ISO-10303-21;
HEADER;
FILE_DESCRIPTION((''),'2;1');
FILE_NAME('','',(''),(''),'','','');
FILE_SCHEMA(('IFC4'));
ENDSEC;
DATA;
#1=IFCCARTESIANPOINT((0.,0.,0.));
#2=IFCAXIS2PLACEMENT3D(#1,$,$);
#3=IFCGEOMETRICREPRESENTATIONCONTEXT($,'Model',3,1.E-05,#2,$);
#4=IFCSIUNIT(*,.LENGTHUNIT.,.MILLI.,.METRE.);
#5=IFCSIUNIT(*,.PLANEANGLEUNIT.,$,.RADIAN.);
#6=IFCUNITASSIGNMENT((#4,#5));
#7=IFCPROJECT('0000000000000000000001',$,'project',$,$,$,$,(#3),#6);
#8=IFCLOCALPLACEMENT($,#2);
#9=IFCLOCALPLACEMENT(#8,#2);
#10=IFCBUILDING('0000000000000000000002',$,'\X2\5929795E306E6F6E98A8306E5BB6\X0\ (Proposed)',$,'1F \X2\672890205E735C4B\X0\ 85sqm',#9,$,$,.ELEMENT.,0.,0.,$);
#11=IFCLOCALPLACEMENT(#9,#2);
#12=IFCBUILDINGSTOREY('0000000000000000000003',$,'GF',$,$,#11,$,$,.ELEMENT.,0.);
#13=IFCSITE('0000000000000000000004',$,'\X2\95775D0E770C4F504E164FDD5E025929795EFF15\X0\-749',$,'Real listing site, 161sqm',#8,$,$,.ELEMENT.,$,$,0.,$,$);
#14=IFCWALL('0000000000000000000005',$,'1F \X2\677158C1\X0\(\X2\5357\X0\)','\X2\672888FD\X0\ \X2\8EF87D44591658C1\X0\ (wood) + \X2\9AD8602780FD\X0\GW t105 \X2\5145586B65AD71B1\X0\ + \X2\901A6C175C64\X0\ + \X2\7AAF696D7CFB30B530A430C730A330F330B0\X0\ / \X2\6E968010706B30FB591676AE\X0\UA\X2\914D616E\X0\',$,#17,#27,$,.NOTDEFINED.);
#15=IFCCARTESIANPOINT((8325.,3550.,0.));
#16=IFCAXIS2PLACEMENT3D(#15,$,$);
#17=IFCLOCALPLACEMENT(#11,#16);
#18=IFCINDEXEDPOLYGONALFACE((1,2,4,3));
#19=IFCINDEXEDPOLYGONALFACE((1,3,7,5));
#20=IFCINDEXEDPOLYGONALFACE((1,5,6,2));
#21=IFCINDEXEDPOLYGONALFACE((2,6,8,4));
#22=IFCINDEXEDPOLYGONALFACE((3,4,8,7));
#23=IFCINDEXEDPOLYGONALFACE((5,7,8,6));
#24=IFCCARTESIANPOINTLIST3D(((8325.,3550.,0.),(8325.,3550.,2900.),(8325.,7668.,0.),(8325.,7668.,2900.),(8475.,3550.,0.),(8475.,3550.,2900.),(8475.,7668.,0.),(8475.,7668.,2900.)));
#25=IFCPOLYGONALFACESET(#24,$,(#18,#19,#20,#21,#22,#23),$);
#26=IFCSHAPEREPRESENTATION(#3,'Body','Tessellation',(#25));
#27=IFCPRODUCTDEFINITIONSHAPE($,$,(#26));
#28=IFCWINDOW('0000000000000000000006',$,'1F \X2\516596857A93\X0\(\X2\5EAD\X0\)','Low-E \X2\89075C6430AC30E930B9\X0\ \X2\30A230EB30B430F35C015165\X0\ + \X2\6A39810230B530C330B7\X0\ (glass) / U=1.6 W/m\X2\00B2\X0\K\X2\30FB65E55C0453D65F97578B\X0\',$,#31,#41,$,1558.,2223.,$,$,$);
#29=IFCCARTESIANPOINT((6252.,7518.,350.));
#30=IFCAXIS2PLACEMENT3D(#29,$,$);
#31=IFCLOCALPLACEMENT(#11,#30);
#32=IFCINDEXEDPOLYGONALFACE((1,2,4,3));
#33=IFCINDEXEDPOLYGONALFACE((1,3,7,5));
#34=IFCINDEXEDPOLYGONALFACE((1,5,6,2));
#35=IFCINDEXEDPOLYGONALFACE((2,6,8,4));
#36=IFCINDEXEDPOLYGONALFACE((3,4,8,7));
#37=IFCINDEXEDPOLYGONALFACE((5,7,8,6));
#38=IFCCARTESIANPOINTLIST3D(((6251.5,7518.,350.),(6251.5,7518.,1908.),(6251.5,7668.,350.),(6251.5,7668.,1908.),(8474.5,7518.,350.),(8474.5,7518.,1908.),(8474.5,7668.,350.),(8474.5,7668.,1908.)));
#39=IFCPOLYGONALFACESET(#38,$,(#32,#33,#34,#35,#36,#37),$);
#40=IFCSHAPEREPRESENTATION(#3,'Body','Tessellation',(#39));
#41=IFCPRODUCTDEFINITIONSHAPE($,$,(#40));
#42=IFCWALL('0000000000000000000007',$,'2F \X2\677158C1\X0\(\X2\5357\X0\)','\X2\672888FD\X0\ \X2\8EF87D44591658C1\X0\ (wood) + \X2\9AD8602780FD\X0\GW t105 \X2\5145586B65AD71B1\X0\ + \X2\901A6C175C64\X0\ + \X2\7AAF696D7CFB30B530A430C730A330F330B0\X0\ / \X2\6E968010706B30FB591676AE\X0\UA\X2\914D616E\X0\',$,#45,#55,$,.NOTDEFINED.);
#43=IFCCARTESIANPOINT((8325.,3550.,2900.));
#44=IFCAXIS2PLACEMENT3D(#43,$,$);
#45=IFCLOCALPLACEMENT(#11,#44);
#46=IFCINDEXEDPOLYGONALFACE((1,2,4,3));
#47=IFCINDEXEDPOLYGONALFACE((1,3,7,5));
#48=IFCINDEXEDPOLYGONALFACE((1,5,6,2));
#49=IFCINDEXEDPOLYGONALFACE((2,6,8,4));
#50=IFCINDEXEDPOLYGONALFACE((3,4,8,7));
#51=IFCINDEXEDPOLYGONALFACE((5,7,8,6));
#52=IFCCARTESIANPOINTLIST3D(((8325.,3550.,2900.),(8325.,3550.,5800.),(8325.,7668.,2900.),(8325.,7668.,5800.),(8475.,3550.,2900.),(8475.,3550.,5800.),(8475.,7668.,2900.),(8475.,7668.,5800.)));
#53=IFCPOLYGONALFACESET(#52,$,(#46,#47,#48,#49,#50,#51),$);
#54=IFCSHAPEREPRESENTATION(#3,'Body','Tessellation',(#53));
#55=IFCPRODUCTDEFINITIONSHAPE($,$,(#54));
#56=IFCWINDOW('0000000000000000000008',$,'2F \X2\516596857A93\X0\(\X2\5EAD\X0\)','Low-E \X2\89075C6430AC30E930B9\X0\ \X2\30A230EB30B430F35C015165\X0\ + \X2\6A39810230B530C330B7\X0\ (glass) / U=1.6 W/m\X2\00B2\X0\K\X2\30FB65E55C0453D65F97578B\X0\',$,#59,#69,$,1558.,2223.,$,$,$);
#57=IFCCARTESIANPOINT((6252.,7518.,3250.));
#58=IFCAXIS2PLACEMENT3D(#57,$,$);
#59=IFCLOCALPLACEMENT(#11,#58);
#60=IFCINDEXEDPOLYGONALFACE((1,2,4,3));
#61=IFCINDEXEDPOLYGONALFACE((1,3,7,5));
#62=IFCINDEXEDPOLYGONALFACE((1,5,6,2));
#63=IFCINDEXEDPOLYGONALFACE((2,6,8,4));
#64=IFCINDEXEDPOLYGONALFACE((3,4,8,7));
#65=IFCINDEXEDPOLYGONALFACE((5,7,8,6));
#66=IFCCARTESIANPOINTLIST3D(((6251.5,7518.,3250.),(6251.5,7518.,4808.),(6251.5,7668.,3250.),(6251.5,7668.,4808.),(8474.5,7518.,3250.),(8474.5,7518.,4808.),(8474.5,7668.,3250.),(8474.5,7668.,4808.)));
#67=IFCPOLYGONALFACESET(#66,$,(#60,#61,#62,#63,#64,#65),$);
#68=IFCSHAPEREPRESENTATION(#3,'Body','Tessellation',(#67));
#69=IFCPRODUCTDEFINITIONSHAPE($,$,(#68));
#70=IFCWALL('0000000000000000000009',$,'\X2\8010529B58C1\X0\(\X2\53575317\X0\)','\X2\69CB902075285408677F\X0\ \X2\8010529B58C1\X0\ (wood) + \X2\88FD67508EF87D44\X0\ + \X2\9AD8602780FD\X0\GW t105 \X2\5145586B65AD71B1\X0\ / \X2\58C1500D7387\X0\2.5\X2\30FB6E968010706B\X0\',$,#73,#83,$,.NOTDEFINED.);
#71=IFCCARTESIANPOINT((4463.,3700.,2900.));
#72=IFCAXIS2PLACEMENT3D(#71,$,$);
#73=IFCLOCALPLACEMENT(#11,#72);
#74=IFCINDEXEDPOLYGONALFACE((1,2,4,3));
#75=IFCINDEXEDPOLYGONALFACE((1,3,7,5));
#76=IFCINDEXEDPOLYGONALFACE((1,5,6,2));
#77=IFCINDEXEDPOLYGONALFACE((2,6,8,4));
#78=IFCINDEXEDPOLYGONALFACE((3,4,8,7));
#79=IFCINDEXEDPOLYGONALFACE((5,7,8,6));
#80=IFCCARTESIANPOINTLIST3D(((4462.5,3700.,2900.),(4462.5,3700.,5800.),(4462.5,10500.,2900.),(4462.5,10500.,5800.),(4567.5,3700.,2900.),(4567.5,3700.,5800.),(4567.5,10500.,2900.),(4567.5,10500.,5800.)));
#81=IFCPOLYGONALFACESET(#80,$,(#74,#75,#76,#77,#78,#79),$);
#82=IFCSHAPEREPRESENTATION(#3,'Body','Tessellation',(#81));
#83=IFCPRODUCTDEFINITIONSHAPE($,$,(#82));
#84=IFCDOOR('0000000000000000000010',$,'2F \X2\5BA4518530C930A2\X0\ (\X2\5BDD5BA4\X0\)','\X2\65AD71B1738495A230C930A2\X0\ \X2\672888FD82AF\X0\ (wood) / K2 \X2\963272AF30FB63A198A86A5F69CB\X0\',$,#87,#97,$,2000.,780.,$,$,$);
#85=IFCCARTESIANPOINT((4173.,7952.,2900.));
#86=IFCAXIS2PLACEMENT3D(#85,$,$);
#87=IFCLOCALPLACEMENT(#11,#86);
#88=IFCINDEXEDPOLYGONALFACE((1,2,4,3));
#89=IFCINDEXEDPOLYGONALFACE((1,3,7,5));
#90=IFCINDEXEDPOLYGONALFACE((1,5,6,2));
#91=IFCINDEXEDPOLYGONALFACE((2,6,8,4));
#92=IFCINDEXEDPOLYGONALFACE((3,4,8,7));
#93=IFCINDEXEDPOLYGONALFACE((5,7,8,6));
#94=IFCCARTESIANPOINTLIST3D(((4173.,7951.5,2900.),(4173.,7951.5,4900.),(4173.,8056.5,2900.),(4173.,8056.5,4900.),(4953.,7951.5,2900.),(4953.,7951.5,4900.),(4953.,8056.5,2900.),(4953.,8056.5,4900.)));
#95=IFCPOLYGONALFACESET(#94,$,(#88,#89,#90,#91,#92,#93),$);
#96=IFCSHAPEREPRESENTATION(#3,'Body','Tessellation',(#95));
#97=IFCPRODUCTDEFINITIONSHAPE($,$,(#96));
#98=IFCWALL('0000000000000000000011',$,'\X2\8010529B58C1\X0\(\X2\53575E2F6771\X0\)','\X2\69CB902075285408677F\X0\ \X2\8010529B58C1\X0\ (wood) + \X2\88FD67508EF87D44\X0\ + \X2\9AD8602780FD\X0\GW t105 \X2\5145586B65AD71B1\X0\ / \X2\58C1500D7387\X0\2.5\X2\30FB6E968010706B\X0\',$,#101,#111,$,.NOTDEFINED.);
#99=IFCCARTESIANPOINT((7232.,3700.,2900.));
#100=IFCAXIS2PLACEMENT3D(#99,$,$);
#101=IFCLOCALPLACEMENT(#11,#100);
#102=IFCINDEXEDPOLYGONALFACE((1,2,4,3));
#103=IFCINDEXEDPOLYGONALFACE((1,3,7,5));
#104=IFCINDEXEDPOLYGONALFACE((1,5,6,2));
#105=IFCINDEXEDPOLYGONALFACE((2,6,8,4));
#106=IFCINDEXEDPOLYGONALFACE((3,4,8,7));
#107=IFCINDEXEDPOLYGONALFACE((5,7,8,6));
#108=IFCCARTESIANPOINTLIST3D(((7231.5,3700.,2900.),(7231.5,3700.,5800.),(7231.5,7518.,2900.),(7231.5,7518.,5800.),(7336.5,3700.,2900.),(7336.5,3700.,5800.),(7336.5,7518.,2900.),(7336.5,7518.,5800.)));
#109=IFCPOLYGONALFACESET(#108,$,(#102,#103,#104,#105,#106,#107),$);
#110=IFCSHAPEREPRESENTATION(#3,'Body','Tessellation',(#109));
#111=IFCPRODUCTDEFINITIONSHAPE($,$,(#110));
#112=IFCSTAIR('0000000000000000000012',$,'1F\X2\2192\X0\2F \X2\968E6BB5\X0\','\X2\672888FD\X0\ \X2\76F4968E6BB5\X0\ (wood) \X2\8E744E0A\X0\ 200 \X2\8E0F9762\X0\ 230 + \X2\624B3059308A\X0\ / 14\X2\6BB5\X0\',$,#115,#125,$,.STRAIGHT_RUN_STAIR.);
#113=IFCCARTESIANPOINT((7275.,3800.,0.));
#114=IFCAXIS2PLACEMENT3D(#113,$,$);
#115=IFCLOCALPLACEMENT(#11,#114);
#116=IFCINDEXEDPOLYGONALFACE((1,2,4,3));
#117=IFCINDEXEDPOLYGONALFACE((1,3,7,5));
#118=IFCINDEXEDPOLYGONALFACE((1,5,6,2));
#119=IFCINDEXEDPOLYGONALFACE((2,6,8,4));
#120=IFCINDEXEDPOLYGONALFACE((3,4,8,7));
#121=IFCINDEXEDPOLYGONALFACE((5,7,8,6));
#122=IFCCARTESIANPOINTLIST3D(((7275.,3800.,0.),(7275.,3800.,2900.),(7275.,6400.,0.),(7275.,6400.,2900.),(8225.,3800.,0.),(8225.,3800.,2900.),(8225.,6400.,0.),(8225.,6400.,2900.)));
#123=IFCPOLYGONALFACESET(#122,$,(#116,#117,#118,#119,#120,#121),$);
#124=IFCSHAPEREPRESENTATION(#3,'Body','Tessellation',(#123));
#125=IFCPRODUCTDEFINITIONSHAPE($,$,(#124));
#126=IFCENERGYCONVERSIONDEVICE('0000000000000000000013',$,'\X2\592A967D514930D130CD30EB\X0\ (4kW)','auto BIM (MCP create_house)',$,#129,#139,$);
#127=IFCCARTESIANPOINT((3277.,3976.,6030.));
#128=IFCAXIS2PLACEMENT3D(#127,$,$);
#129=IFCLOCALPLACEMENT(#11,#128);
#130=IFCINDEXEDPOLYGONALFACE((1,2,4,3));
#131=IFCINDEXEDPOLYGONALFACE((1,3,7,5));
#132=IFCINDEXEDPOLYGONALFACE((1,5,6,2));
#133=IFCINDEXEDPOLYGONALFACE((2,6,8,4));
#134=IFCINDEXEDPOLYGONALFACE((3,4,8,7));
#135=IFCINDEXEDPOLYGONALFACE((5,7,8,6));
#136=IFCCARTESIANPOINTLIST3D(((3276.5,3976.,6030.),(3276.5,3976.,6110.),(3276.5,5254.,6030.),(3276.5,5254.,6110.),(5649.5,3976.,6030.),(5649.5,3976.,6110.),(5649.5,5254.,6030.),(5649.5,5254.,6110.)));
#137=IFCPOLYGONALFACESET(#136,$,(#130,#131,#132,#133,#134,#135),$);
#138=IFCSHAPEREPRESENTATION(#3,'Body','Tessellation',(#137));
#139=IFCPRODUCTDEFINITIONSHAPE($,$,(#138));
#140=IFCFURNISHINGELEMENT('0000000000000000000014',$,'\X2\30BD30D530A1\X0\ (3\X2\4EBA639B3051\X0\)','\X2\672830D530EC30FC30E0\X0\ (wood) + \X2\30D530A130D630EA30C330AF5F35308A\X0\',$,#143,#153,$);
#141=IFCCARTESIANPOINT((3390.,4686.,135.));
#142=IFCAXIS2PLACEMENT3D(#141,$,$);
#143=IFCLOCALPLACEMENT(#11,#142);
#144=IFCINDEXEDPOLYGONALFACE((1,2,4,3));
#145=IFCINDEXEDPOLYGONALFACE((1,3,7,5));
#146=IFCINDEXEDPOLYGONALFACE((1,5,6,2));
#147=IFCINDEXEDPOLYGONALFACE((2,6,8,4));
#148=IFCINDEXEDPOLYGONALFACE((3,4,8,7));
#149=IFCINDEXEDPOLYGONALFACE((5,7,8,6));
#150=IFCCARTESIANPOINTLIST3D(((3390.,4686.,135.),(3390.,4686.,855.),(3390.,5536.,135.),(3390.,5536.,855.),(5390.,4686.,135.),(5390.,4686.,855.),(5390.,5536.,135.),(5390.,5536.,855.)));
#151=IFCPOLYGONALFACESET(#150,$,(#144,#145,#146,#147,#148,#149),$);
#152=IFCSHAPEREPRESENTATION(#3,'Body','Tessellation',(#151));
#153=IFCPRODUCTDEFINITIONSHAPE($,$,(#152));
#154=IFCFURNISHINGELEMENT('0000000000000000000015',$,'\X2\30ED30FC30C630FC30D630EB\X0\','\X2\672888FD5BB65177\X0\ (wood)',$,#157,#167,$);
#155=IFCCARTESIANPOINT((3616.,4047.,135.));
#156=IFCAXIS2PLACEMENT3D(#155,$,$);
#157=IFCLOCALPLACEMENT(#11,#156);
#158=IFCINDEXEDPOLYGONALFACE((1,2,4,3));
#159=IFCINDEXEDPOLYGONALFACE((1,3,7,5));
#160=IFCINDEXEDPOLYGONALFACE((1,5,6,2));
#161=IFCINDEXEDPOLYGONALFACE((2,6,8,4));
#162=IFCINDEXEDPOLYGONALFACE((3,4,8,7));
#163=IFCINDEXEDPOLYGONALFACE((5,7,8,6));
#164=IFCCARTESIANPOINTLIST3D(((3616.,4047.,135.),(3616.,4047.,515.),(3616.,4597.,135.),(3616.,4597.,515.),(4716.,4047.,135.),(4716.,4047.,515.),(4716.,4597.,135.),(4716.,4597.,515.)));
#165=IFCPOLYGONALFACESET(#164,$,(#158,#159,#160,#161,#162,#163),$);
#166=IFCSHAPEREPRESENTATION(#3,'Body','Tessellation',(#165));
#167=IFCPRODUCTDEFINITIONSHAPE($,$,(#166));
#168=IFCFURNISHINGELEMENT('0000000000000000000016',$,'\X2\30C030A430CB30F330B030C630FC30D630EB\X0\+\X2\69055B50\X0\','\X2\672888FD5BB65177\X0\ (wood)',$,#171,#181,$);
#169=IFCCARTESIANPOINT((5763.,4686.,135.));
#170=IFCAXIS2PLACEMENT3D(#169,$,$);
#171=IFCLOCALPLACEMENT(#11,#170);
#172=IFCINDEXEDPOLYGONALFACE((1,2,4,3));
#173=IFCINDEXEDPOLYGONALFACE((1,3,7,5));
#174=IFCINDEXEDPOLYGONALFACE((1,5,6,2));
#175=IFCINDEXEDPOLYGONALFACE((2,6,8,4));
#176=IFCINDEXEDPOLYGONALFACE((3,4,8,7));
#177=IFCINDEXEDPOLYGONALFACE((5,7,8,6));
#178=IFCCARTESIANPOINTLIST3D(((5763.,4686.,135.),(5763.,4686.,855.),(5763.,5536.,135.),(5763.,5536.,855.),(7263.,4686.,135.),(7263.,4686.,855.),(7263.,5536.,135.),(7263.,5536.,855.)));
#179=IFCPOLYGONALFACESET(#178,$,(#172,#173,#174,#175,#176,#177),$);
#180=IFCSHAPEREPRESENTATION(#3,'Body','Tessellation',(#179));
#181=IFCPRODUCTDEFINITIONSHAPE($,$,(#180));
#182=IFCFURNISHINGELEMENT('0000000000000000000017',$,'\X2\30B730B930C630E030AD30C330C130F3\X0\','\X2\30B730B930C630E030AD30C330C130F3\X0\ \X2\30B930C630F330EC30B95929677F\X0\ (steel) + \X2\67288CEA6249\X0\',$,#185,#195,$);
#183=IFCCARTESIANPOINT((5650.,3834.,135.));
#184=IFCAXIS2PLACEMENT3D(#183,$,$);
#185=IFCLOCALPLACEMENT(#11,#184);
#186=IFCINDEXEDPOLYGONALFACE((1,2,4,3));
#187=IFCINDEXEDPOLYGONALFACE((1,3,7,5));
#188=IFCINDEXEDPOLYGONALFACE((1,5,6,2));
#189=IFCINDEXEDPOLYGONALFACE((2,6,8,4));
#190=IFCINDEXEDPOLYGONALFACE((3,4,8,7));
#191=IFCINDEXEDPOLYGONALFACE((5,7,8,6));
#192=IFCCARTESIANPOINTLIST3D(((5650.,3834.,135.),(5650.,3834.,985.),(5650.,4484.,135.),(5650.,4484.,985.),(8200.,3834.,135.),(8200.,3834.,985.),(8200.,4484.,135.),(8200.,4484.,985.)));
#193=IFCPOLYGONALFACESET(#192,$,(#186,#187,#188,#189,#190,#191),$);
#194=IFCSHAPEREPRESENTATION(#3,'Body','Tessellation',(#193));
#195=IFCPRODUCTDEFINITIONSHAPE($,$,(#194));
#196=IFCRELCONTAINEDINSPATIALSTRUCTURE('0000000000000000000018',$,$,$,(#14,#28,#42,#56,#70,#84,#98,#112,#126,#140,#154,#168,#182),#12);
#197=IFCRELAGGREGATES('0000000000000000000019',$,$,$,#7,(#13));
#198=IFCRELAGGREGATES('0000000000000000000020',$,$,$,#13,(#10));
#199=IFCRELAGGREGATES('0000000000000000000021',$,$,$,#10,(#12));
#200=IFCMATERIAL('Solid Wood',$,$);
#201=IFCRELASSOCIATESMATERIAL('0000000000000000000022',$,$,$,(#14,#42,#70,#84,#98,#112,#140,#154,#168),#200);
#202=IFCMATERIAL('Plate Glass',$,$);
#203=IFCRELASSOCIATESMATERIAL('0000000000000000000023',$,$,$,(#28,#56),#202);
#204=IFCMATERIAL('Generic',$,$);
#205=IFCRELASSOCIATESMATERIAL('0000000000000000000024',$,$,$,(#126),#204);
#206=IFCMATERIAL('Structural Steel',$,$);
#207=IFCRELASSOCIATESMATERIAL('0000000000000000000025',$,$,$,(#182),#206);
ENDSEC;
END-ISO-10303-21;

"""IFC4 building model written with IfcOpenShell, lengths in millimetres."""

from ifc_helpers import new_model, si_unit, frame, frame_2d, origin, place, context, project, spatial, rectangle, extrude, material, element, fill, save


model = new_model("IFC4")

# Units and contexts
model_context = context("Model", 3, precision=1e-05, world=origin())
ifc_project = project(units=[si_unit("LENGTHUNIT", "METRE", prefix="MILLI"), si_unit("PLANEANGLEUNIT", "RADIAN")], contexts=[model_context])

# Site, building, storey
site_placement = place(None, origin())
site = spatial("IfcSite", under=ifc_project, at=site_placement, Name="長崎県佐世保市天神５-749", ObjectType="Real listing site, 161sqm", CompositionType="ELEMENT", RefElevation=0.0)
building_placement = place(site_placement, origin())
building = spatial("IfcBuilding", under=site, at=building_placement, Name="天神の潮風の家 (Proposed)", ObjectType="1F 木造平屋 85sqm", CompositionType="ELEMENT", ElevationOfRefHeight=0.0, ElevationOfTerrain=0.0)
storey_placement = place(building_placement, origin())
storey = spatial("IfcBuildingStorey", under=building, at=storey_placement, Name="GF", CompositionType="ELEMENT", Elevation=0.0)

# Wall, opening, window
ifc_material_1 = material(Name="Solid Wood")
wall_1_placement = place(storey_placement, frame((8325.0, 3550.0, 0.0)))
wall_1 = element("IfcWall", 1, at=wall_1_placement, inside=storey, material=ifc_material_1, Name="1F 東壁(南)", Description="木製 軸組外壁 (wood) + 高性能GW t105 充填断熱 + 通気層 + 窯業系サイディング / 準耐火・外皮UA配慮", PredefinedType="NOTDEFINED", context=model_context, shape_type="SweptSolid", body=[
    extrude(rectangle(XDim=150.0, YDim=4118.0, at=frame_2d((75.0, 2059.0))), frame((8325.0, 3550.0, 0.0)), (0.0, 0.0, 1.0), 2900.0),
])
opening_1_placement = place(storey_placement, frame((6252.0, 7518.0, 350.0)))
opening_1 = element("IfcOpeningElement", 2, at=opening_1_placement, cuts=wall_1, PredefinedType="NOTDEFINED", context=model_context, shape_type="SweptSolid", body=[
    extrude(rectangle(XDim=2223.0, YDim=150.0, at=frame_2d((1111.0, 75.0))), frame((6252.0, 7518.0, 350.0)), (0.0, 0.0, 1.0), 1558.0),
])
ifc_material_2 = material(Name="Plate Glass")
window_1_placement = place(storey_placement, frame((6252.0, 7518.0, 350.0)))
window_1 = element("IfcWindow", 3, at=window_1_placement, inside=storey, material=ifc_material_2, Name="1F 入隅窓(庭)", Description="Low-E 複層ガラス アルゴン封入 + 樹脂サッシ (glass) / U=1.6 W/m²K・日射取得型", OverallHeight=1558.0, OverallWidth=2223.0, context=model_context, shape_type="SweptSolid", body=[
    extrude(rectangle(XDim=2223.0, YDim=150.0, at=frame_2d((1111.0, 75.0))), frame((6252.0, 7518.0, 350.0)), (0.0, 0.0, 1.0), 1558.0),
])
fill(opening_1, window_1)

# Wall, opening, window
wall_2_placement = place(storey_placement, frame((8325.0, 3550.0, 2900.0)))
wall_2 = element("IfcWall", 4, at=wall_2_placement, inside=storey, material=ifc_material_1, Name="2F 東壁(南)", Description="木製 軸組外壁 (wood) + 高性能GW t105 充填断熱 + 通気層 + 窯業系サイディング / 準耐火・外皮UA配慮", PredefinedType="NOTDEFINED", context=model_context, shape_type="SweptSolid", body=[
    extrude(rectangle(XDim=150.0, YDim=4118.0, at=frame_2d((75.0, 2059.0))), frame((8325.0, 3550.0, 2900.0)), (0.0, 0.0, 1.0), 2900.0),
])
opening_2_placement = place(storey_placement, frame((6252.0, 7518.0, 3250.0)))
opening_2 = element("IfcOpeningElement", 5, at=opening_2_placement, cuts=wall_2, PredefinedType="NOTDEFINED", context=model_context, shape_type="SweptSolid", body=[
    extrude(rectangle(XDim=2223.0, YDim=150.0, at=frame_2d((1111.0, 75.0))), frame((6252.0, 7518.0, 3250.0)), (0.0, 0.0, 1.0), 1558.0),
])
window_2_placement = place(storey_placement, frame((6252.0, 7518.0, 3250.0)))
window_2 = element("IfcWindow", 6, at=window_2_placement, inside=storey, material=ifc_material_2, Name="2F 入隅窓(庭)", Description="Low-E 複層ガラス アルゴン封入 + 樹脂サッシ (glass) / U=1.6 W/m²K・日射取得型", OverallHeight=1558.0, OverallWidth=2223.0, context=model_context, shape_type="SweptSolid", body=[
    extrude(rectangle(XDim=2223.0, YDim=150.0, at=frame_2d((1111.0, 75.0))), frame((6252.0, 7518.0, 3250.0)), (0.0, 0.0, 1.0), 1558.0),
])
fill(opening_2, window_2)

# Wall, opening, door
wall_3_placement = place(storey_placement, frame((4463.0, 3700.0, 2900.0)))
wall_3 = element("IfcWall", 7, at=wall_3_placement, inside=storey, material=ifc_material_1, Name="耐力壁(南北)", Description="構造用合板 耐力壁 (wood) + 製材軸組 + 高性能GW t105 充填断熱 / 壁倍率2.5・準耐火", PredefinedType="NOTDEFINED", context=model_context, shape_type="SweptSolid", body=[
    extrude(rectangle(XDim=105.0, YDim=6800.0, at=frame_2d((52.0, 3400.0))), frame((4463.0, 3700.0, 2900.0)), (0.0, 0.0, 1.0), 2900.0),
])
opening_3_placement = place(storey_placement, frame((4173.0, 7952.0, 2900.0)))
opening_3 = element("IfcOpeningElement", 8, at=opening_3_placement, cuts=wall_3, PredefinedType="NOTDEFINED", context=model_context, shape_type="SweptSolid", body=[
    extrude(rectangle(XDim=780.0, YDim=105.0, at=frame_2d((390.0, 52.0))), frame((4173.0, 7952.0, 2900.0)), (0.0, 0.0, 1.0), 2000.0),
])
door_1_placement = place(storey_placement, frame((4173.0, 7952.0, 2900.0)))
door_1 = element("IfcDoor", 9, at=door_1_placement, inside=storey, material=ifc_material_1, Name="2F 室内ドア (寝室)", Description="断熱玄関ドア 木製芯 (wood) / K2 防犯・採風機構", OverallHeight=2000.0, OverallWidth=780.0, context=model_context, shape_type="SweptSolid", body=[
    extrude(rectangle(XDim=780.0, YDim=105.0, at=frame_2d((390.0, 52.0))), frame((4173.0, 7952.0, 2900.0)), (0.0, 0.0, 1.0), 2000.0),
])
fill(opening_3, door_1)

# Wall
wall_4_placement = place(storey_placement, frame((7232.0, 3700.0, 2900.0)))
element("IfcWall", 10, at=wall_4_placement, inside=storey, material=ifc_material_1, Name="耐力壁(南帯東)", Description="構造用合板 耐力壁 (wood) + 製材軸組 + 高性能GW t105 充填断熱 / 壁倍率2.5・準耐火", PredefinedType="NOTDEFINED", context=model_context, shape_type="SweptSolid", body=[
    extrude(rectangle(XDim=105.0, YDim=3818.0, at=frame_2d((52.0, 1909.0))), frame((7232.0, 3700.0, 2900.0)), (0.0, 0.0, 1.0), 2900.0),
])

# Stair
stair_placement = place(storey_placement, frame((7275.0, 3800.0, 0.0)))
element("IfcStair", 11, at=stair_placement, inside=storey, material=ifc_material_1, Name="1F→2F 階段", Description="木製 直階段 (wood) 蹴上 200 踏面 230 + 手すり / 14段", PredefinedType="STRAIGHT_RUN_STAIR", context=model_context, shape_type="SweptSolid", body=[
    extrude(rectangle(XDim=950.0, YDim=2600.0, at=frame_2d((475.0, 1300.0))), frame((7275.0, 3800.0, 0.0)), (0.0, 0.0, 1.0), 2900.0),
])

# Energy conversion device
ifc_material_3 = material(Name="Generic")
energy_conversion_device_placement = place(storey_placement, frame((3277.0, 3976.0, 6030.0)))
element("IfcEnergyConversionDevice", 12, at=energy_conversion_device_placement, inside=storey, material=ifc_material_3, Name="太陽光パネル (4kW)", Description="auto BIM (MCP create_house)", context=model_context, shape_type="SweptSolid", body=[
    extrude(rectangle(XDim=2373.0, YDim=1278.0, at=frame_2d((1186.0, 639.0))), frame((3277.0, 3976.0, 6030.0)), (0.0, 0.0, 1.0), 80.0),
])

# Furnishing elements
furnishing_1_placement = place(storey_placement, frame((3390.0, 4686.0, 135.0)))
element("IfcFurnishingElement", 13, at=furnishing_1_placement, inside=storey, material=ifc_material_1, Name="ソファ (3人掛け)", Description="木フレーム (wood) + ファブリック張り", context=model_context, shape_type="SweptSolid", body=[
    extrude(rectangle(XDim=2000.0, YDim=850.0, at=frame_2d((1000.0, 425.0))), frame((3390.0, 4686.0, 135.0)), (0.0, 0.0, 1.0), 720.0),
])
furnishing_2_placement = place(storey_placement, frame((3616.0, 4047.0, 135.0)))
element("IfcFurnishingElement", 14, at=furnishing_2_placement, inside=storey, material=ifc_material_1, Name="ローテーブル", Description="木製家具 (wood)", context=model_context, shape_type="SweptSolid", body=[
    extrude(rectangle(XDim=1100.0, YDim=550.0, at=frame_2d((550.0, 275.0))), frame((3616.0, 4047.0, 135.0)), (0.0, 0.0, 1.0), 380.0),
])
furnishing_3_placement = place(storey_placement, frame((5763.0, 4686.0, 135.0)))
element("IfcFurnishingElement", 15, at=furnishing_3_placement, inside=storey, material=ifc_material_1, Name="ダイニングテーブル+椅子", Description="木製家具 (wood)", context=model_context, shape_type="SweptSolid", body=[
    extrude(rectangle(XDim=1500.0, YDim=850.0, at=frame_2d((750.0, 425.0))), frame((5763.0, 4686.0, 135.0)), (0.0, 0.0, 1.0), 720.0),
])
ifc_material_4 = material(Name="Structural Steel")
furnishing_4_placement = place(storey_placement, frame((5650.0, 3834.0, 135.0)))
element("IfcFurnishingElement", 16, at=furnishing_4_placement, inside=storey, material=ifc_material_4, Name="システムキッチン", Description="システムキッチン ステンレス天板 (steel) + 木質扉", context=model_context, shape_type="SweptSolid", body=[
    extrude(rectangle(XDim=2550.0, YDim=650.0, at=frame_2d((1275.0, 325.0))), frame((5650.0, 3834.0, 135.0)), (0.0, 0.0, 1.0), 850.0),
])

save(model, "model.ifc")
